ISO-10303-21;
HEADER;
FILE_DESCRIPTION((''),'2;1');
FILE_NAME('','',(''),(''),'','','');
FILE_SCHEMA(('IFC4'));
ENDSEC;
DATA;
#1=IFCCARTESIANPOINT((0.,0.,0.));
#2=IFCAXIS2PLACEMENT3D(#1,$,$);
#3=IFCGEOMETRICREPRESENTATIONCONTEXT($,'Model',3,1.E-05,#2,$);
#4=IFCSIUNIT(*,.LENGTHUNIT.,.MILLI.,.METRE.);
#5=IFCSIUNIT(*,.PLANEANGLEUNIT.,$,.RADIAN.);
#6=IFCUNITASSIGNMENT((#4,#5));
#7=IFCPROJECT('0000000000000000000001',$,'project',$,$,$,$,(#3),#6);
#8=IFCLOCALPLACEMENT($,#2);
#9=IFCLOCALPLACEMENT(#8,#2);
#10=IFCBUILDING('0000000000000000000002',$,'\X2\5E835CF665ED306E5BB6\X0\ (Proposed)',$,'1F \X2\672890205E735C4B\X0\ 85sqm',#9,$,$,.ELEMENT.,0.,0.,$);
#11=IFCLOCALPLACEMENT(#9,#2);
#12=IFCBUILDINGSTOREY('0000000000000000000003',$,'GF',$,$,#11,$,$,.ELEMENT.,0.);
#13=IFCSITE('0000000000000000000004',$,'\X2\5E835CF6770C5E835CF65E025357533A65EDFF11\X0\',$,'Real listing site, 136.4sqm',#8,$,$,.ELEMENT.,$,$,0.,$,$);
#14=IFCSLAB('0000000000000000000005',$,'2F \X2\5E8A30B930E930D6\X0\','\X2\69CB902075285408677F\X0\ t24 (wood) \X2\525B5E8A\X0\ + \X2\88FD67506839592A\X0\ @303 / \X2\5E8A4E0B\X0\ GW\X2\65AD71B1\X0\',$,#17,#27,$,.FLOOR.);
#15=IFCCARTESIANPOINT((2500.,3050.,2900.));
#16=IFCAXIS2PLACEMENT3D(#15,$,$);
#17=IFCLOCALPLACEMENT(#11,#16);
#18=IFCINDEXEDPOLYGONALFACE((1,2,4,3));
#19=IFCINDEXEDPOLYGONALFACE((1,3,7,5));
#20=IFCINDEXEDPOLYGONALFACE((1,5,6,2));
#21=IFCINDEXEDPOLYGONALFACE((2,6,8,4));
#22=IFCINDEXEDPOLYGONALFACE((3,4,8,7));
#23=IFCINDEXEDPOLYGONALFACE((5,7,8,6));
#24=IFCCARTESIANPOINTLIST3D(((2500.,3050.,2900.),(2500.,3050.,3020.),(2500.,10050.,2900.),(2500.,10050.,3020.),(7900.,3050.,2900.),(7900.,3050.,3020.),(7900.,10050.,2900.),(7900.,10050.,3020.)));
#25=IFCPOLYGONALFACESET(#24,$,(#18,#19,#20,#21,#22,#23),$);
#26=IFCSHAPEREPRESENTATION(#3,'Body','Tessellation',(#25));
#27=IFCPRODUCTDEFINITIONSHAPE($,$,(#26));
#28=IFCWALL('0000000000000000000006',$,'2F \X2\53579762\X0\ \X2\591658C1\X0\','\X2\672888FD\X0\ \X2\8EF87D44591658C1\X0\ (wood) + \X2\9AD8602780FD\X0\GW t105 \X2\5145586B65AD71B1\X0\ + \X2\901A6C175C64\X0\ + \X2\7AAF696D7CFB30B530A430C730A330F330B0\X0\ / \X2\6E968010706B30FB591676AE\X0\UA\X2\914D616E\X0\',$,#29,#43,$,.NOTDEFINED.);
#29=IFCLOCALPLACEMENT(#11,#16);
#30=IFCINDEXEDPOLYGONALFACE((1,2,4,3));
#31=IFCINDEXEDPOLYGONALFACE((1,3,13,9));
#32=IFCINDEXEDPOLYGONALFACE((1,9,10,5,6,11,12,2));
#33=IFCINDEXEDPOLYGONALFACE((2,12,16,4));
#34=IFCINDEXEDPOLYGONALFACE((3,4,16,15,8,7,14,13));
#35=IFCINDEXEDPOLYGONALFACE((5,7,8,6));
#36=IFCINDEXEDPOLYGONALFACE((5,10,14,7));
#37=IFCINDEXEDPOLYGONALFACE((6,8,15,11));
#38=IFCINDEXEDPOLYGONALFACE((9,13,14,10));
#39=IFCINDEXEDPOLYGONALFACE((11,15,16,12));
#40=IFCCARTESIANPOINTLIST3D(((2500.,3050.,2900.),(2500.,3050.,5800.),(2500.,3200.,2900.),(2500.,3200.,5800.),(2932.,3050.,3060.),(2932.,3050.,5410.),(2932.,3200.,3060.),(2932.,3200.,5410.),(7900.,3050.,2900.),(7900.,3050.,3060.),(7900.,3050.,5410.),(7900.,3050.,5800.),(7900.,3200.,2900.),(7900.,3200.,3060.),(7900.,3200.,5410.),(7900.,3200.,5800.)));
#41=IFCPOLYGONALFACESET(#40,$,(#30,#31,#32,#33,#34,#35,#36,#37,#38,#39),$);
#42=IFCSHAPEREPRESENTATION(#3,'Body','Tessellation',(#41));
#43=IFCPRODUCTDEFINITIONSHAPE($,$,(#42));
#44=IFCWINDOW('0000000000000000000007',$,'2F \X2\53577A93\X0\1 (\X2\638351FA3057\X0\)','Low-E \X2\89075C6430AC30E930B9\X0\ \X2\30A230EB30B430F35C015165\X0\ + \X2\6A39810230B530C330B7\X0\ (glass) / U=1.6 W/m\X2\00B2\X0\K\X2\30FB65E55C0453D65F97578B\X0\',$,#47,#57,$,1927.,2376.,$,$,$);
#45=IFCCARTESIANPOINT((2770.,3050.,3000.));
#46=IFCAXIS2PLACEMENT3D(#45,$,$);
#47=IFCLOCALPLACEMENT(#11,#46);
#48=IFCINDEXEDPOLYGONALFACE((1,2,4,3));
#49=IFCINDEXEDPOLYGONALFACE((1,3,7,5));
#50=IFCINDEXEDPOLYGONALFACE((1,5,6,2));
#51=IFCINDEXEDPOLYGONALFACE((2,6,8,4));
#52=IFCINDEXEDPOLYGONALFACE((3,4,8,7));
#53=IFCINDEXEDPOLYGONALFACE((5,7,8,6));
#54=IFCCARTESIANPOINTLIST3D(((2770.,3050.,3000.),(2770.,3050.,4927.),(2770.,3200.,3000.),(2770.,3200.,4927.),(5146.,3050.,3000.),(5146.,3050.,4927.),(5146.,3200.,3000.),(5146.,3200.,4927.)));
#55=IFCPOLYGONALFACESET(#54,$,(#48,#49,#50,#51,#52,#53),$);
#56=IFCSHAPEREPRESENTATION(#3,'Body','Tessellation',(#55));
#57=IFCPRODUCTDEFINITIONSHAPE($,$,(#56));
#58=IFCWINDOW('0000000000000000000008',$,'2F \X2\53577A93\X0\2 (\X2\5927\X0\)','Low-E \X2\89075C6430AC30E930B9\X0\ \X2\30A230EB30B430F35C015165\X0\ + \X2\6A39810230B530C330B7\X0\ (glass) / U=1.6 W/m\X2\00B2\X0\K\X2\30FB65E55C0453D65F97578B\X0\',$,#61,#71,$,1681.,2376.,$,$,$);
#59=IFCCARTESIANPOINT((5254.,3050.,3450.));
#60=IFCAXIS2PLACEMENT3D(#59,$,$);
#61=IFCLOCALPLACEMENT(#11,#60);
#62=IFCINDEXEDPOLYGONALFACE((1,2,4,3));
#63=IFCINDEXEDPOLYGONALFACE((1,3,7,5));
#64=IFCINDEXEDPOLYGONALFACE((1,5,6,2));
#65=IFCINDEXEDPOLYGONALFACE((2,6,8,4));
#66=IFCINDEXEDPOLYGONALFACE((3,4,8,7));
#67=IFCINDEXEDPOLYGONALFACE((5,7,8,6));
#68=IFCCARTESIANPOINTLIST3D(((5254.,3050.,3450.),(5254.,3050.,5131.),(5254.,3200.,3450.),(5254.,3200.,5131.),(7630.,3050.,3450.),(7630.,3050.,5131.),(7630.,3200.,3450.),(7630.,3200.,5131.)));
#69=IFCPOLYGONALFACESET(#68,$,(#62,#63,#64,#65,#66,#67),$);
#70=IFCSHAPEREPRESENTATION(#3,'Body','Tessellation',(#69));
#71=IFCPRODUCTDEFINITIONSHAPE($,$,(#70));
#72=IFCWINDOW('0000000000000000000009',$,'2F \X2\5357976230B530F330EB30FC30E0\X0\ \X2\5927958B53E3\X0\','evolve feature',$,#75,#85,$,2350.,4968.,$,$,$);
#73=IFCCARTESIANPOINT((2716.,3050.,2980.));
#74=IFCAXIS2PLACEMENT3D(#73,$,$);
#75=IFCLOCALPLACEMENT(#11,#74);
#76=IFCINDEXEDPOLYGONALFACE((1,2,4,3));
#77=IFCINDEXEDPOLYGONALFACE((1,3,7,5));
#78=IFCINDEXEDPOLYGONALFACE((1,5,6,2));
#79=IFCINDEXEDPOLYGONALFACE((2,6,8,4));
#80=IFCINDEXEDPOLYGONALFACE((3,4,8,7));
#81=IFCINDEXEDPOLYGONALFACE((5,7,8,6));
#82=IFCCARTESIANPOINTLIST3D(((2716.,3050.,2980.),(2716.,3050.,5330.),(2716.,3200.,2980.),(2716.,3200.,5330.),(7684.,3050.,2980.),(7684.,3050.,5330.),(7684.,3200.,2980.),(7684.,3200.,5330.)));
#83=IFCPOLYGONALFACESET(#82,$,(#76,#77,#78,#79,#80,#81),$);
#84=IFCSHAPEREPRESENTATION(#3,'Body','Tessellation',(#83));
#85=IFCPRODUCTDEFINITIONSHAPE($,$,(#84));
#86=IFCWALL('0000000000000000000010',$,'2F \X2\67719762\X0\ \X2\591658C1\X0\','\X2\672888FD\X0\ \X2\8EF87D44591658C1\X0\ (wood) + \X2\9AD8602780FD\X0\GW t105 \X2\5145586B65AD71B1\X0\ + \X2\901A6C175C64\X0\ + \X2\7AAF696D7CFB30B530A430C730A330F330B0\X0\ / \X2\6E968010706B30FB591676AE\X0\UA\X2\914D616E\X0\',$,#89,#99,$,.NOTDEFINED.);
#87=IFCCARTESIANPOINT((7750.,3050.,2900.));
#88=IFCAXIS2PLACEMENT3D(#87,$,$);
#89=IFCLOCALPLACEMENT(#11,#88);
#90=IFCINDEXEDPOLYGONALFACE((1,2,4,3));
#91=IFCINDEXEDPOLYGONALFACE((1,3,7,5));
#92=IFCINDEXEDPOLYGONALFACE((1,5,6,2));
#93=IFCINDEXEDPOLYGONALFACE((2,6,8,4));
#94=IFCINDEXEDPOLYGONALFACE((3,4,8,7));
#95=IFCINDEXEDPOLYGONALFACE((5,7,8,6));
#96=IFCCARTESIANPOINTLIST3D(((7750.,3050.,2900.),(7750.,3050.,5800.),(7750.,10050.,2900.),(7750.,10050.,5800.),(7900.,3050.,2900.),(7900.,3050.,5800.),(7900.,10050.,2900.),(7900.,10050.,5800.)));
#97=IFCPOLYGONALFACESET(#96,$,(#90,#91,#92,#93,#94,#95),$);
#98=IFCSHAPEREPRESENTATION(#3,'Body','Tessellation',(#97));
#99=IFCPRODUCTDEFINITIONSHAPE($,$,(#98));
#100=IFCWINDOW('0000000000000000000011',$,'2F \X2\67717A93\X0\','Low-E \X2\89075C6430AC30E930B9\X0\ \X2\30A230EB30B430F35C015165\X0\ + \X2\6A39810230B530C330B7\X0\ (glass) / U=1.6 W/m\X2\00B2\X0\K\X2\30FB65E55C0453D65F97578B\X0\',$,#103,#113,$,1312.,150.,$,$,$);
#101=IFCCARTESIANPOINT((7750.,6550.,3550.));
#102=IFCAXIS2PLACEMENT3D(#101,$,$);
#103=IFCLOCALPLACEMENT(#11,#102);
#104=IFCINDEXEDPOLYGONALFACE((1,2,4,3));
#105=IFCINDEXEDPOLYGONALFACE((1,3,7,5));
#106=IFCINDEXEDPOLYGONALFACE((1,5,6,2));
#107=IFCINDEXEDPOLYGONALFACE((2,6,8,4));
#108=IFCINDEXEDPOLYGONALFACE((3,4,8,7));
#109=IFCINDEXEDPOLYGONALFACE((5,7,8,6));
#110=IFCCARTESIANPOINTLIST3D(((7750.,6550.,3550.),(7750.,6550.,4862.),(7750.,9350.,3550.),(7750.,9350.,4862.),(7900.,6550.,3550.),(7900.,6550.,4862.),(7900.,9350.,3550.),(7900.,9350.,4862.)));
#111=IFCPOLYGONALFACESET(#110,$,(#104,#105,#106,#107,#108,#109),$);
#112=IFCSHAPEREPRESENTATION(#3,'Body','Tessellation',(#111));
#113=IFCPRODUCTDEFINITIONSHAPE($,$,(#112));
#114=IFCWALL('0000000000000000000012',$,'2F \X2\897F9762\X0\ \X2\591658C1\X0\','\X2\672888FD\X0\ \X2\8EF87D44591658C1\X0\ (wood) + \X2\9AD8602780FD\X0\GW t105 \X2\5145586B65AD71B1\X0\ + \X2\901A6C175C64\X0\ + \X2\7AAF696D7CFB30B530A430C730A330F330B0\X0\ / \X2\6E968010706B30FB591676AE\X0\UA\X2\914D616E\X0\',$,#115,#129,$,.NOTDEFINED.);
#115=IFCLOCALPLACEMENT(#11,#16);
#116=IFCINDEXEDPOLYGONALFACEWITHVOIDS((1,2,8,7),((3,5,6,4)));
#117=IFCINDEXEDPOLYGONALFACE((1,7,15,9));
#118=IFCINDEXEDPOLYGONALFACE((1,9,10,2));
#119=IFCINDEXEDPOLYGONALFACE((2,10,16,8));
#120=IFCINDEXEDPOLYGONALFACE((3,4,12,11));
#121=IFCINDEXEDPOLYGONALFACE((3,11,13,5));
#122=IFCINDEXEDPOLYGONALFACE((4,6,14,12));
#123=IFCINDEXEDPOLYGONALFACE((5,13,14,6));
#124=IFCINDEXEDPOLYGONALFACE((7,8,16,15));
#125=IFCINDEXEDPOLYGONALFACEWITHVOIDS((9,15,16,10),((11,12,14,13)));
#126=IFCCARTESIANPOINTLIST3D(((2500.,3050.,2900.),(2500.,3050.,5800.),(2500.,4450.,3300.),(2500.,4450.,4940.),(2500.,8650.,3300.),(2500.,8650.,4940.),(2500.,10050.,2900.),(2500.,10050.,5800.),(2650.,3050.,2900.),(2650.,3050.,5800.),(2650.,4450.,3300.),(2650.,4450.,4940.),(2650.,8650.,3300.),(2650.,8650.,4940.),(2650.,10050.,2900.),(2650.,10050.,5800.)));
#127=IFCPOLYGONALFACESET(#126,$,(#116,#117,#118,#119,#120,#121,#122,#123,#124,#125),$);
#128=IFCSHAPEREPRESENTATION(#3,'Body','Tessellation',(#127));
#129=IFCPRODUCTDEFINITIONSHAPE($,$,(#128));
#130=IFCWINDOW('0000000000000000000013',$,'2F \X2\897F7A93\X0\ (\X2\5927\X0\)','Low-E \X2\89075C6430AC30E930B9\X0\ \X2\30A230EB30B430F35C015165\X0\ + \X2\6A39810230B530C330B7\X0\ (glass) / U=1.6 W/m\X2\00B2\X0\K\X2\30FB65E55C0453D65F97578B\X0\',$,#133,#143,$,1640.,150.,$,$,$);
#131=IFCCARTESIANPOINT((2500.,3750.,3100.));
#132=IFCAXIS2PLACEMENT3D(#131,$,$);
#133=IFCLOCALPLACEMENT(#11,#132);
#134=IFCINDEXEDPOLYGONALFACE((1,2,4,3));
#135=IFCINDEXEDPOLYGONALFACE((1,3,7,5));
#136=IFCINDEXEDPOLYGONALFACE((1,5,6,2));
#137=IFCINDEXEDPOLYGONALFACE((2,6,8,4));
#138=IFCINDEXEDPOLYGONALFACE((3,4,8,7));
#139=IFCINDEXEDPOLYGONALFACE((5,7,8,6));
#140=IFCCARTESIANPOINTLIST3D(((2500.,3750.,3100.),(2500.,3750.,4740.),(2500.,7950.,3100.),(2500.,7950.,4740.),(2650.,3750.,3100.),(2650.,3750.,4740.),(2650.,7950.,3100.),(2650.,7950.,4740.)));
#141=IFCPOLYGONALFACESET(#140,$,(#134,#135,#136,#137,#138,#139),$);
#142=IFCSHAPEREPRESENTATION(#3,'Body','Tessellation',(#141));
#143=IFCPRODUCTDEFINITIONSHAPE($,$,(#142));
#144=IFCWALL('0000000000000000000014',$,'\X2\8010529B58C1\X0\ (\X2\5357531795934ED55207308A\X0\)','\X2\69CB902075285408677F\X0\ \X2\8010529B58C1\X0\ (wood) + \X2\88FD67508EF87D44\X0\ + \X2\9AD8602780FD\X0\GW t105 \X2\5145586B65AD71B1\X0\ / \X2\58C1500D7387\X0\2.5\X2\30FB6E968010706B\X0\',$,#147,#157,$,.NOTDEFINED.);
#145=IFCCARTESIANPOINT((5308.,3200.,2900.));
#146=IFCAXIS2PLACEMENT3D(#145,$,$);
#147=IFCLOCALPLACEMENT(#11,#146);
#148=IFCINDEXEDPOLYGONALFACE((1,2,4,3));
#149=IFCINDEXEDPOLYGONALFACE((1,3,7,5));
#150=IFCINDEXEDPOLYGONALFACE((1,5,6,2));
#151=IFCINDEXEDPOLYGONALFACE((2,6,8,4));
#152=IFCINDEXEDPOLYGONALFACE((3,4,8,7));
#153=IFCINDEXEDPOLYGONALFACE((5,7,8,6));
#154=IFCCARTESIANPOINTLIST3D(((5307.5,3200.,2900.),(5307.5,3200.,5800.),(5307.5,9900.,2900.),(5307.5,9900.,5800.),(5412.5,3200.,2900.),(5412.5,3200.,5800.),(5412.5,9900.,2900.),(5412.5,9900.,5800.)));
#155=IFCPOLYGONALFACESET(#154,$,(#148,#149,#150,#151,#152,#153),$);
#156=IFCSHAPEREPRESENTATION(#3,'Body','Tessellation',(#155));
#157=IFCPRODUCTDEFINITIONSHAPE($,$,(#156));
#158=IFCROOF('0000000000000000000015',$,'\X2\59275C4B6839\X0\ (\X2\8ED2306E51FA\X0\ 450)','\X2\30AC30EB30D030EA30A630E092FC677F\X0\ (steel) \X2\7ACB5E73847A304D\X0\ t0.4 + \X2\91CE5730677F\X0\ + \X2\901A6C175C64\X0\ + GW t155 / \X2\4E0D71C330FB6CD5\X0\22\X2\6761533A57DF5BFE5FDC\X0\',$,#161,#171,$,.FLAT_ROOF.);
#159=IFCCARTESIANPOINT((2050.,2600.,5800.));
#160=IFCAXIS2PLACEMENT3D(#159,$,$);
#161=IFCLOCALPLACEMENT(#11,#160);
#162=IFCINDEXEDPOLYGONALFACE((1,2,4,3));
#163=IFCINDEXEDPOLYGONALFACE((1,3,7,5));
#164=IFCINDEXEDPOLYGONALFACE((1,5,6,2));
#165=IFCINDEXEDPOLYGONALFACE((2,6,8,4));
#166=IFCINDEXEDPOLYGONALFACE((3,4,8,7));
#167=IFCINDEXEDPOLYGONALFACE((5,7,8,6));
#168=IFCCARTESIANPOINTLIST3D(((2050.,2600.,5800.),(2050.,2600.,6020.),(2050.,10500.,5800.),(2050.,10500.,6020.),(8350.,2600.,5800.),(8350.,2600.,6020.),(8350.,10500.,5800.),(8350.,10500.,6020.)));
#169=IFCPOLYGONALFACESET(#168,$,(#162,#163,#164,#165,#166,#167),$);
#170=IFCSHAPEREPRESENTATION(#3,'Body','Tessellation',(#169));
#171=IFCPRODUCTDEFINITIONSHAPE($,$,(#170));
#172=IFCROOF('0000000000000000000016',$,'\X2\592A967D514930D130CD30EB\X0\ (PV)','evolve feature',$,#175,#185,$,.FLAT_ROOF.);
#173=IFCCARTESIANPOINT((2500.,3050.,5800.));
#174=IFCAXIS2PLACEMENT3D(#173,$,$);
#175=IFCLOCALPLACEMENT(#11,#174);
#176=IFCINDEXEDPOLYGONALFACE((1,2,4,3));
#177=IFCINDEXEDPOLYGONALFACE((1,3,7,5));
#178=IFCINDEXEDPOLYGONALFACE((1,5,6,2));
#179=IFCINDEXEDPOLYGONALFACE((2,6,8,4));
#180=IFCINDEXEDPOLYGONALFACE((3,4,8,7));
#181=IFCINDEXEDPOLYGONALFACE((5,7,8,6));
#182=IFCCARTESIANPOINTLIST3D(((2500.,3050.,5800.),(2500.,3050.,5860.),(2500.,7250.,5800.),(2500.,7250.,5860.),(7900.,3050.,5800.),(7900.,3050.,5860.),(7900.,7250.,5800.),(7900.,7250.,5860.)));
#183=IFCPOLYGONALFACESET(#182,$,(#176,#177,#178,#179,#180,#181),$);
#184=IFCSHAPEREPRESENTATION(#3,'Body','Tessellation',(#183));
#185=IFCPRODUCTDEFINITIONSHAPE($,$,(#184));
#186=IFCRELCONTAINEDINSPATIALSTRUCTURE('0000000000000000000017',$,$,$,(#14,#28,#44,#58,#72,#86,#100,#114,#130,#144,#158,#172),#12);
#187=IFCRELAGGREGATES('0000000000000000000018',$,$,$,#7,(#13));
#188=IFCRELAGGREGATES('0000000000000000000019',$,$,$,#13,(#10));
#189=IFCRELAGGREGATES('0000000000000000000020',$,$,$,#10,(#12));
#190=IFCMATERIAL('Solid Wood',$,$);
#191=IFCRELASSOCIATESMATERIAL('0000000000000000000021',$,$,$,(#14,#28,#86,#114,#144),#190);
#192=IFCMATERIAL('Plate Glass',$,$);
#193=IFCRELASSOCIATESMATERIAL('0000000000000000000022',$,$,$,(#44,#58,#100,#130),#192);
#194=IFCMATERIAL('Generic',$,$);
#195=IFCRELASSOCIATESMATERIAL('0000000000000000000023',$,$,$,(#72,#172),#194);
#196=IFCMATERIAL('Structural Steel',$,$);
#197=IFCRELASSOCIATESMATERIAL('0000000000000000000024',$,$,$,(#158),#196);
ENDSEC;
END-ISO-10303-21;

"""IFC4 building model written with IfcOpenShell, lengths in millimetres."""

from ifc_helpers import new_model, si_unit, frame, frame_2d, origin, place, context, project, spatial, rectangle, extrude, material, element, fill, save


model = new_model("IFC4")

# Units and contexts
model_context = context("Model", 3, precision=1e-05, world=origin())
ifc_project = project(units=[si_unit("LENGTHUNIT", "METRE", prefix="MILLI"), si_unit("PLANEANGLEUNIT", "RADIAN")], contexts=[model_context])

# Site, building, storey
site_placement = place(None, origin())
site = spatial("IfcSite", under=ifc_project, at=site_placement, Name="広島県広島市南区旭１", ObjectType="Real listing site, 136.4sqm", CompositionType="ELEMENT", RefElevation=0.0)
building_placement = place(site_placement, origin())
building = spatial("IfcBuilding", under=site, at=building_placement, Name="広島旭の家 (Proposed)", ObjectType="1F 木造平屋 85sqm", CompositionType="ELEMENT", ElevationOfRefHeight=0.0, ElevationOfTerrain=0.0)
storey_placement = place(building_placement, origin())
storey = spatial("IfcBuildingStorey", under=building, at=storey_placement, Name="GF", CompositionType="ELEMENT", Elevation=0.0)

# Slab
ifc_material_1 = material(Name="Solid Wood")
slab_placement = place(storey_placement, frame((2500.0, 3050.0, 2900.0)))
element("IfcSlab", 1, at=slab_placement, inside=storey, material=ifc_material_1, Name="2F 床スラブ", Description="構造用合板 t24 (wood) 剛床 + 製材根太 @303 / 床下 GW断熱", PredefinedType="FLOOR", context=model_context, shape_type="SweptSolid", body=[
    extrude(rectangle(XDim=5400.0, YDim=7000.0, at=frame_2d((2700.0, 3500.0))), frame((2500.0, 3050.0, 2900.0)), (0.0, 0.0, 1.0), 120.0),
])

# Wall, openings, windows
wall_1_placement = place(storey_placement, frame((2500.0, 3050.0, 2900.0)))
wall_1 = element("IfcWall", 2, at=wall_1_placement, inside=storey, material=ifc_material_1, Name="2F 南面 外壁", Description="木製 軸組外壁 (wood) + 高性能GW t105 充填断熱 + 通気層 + 窯業系サイディング / 準耐火・外皮UA配慮", PredefinedType="NOTDEFINED", context=model_context, shape_type="SweptSolid", body=[
    extrude(rectangle(XDim=5400.0, YDim=150.0, at=frame_2d((2700.0, 75.0))), frame((2500.0, 3050.0, 2900.0)), (0.0, 0.0, 1.0), 2900.0),
])
opening_1_placement = place(storey_placement, frame((2770.0, 3050.0, 3000.0)))
opening_1 = element("IfcOpeningElement", 3, at=opening_1_placement, cuts=wall_1, PredefinedType="NOTDEFINED", context=model_context, shape_type="SweptSolid", body=[
    extrude(rectangle(XDim=2376.0, YDim=150.0, at=frame_2d((1188.0, 75.0))), frame((2770.0, 3050.0, 3000.0)), (0.0, 0.0, 1.0), 1927.0),
])
opening_2_placement = place(storey_placement, frame((5254.0, 3050.0, 3450.0)))
opening_2 = element("IfcOpeningElement", 4, at=opening_2_placement, cuts=wall_1, PredefinedType="NOTDEFINED", context=model_context, shape_type="SweptSolid", body=[
    extrude(rectangle(XDim=2376.0, YDim=150.0, at=frame_2d((1188.0, 75.0))), frame((5254.0, 3050.0, 3450.0)), (0.0, 0.0, 1.0), 1681.0),
])
opening_3_placement = place(storey_placement, frame((2716.0, 3050.0, 2980.0)))
opening_3 = element("IfcOpeningElement", 5, at=opening_3_placement, cuts=wall_1, PredefinedType="NOTDEFINED", context=model_context, shape_type="SweptSolid", body=[
    extrude(rectangle(XDim=4968.0, YDim=150.0, at=frame_2d((2484.0, 75.0))), frame((2716.0, 3050.0, 2980.0)), (0.0, 0.0, 1.0), 2350.0),
])
ifc_material_2 = material(Name="Plate Glass")
window_1_placement = place(storey_placement, frame((2770.0, 3050.0, 3000.0)))
window_1 = element("IfcWindow", 6, at=window_1_placement, inside=storey, material=ifc_material_2, Name="2F 南窓1 (掃出し)", Description="Low-E 複層ガラス アルゴン封入 + 樹脂サッシ (glass) / U=1.6 W/m²K・日射取得型", OverallHeight=1927.0, OverallWidth=2376.0, context=model_context, shape_type="SweptSolid", body=[
    extrude(rectangle(XDim=2376.0, YDim=150.0, at=frame_2d((1188.0, 75.0))), frame((2770.0, 3050.0, 3000.0)), (0.0, 0.0, 1.0), 1927.0),
])
fill(opening_1, window_1)
window_2_placement = place(storey_placement, frame((5254.0, 3050.0, 3450.0)))
window_2 = element("IfcWindow", 7, at=window_2_placement, inside=storey, material=ifc_material_2, Name="2F 南窓2 (大)", Description="Low-E 複層ガラス アルゴン封入 + 樹脂サッシ (glass) / U=1.6 W/m²K・日射取得型", OverallHeight=1681.0, OverallWidth=2376.0, context=model_context, shape_type="SweptSolid", body=[
    extrude(rectangle(XDim=2376.0, YDim=150.0, at=frame_2d((1188.0, 75.0))), frame((5254.0, 3050.0, 3450.0)), (0.0, 0.0, 1.0), 1681.0),
])
fill(opening_2, window_2)
ifc_material_3 = material(Name="Generic")
window_3_placement = place(storey_placement, frame((2716.0, 3050.0, 2980.0)))
window_3 = element("IfcWindow", 8, at=window_3_placement, inside=storey, material=ifc_material_3, Name="2F 南面サンルーム 大開口", Description="evolve feature", OverallHeight=2350.0, OverallWidth=4968.0, context=model_context, shape_type="SweptSolid", body=[
    extrude(rectangle(XDim=4968.0, YDim=150.0, at=frame_2d((2484.0, 75.0))), frame((2716.0, 3050.0, 2980.0)), (0.0, 0.0, 1.0), 2350.0),
])
fill(opening_3, window_3)

# Walls, openings, windows
wall_2_placement = place(storey_placement, frame((7750.0, 3050.0, 2900.0)))
wall_2 = element("IfcWall", 9, at=wall_2_placement, inside=storey, material=ifc_material_1, Name="2F 東面 外壁", Description="木製 軸組外壁 (wood) + 高性能GW t105 充填断熱 + 通気層 + 窯業系サイディング / 準耐火・外皮UA配慮", PredefinedType="NOTDEFINED", context=model_context, shape_type="SweptSolid", body=[
    extrude(rectangle(XDim=150.0, YDim=7000.0, at=frame_2d((75.0, 3500.0))), frame((7750.0, 3050.0, 2900.0)), (0.0, 0.0, 1.0), 2900.0),
])
opening_4_placement = place(storey_placement, frame((7750.0, 6550.0, 3550.0)))
opening_4 = element("IfcOpeningElement", 10, at=opening_4_placement, cuts=wall_2, PredefinedType="NOTDEFINED", context=model_context, shape_type="SweptSolid", body=[
    extrude(rectangle(XDim=150.0, YDim=2800.0, at=frame_2d((75.0, 1400.0))), frame((7750.0, 6550.0, 3550.0)), (0.0, 0.0, 1.0), 1312.0),
])
window_4_placement = place(storey_placement, frame((7750.0, 6550.0, 3550.0)))
window_4 = element("IfcWindow", 11, at=window_4_placement, inside=storey, material=ifc_material_2, Name="2F 東窓", Description="Low-E 複層ガラス アルゴン封入 + 樹脂サッシ (glass) / U=1.6 W/m²K・日射取得型", OverallHeight=1312.0, OverallWidth=150.0, context=model_context, shape_type="SweptSolid", body=[
    extrude(rectangle(XDim=150.0, YDim=2800.0, at=frame_2d((75.0, 1400.0))), frame((7750.0, 6550.0, 3550.0)), (0.0, 0.0, 1.0), 1312.0),
])
fill(opening_4, window_4)
wall_3_placement = place(storey_placement, frame((2500.0, 3050.0, 2900.0)))
wall_3 = element("IfcWall", 12, at=wall_3_placement, inside=storey, material=ifc_material_1, Name="2F 西面 外壁", Description="木製 軸組外壁 (wood) + 高性能GW t105 充填断熱 + 通気層 + 窯業系サイディング / 準耐火・外皮UA配慮", PredefinedType="NOTDEFINED", context=model_context, shape_type="SweptSolid", body=[
    extrude(rectangle(XDim=150.0, YDim=7000.0, at=frame_2d((75.0, 3500.0))), frame((2500.0, 3050.0, 2900.0)), (0.0, 0.0, 1.0), 2900.0),
])
opening_5_placement = place(storey_placement, frame((2500.0, 3750.0, 3100.0)))
opening_5 = element("IfcOpeningElement", 13, at=opening_5_placement, cuts=wall_3, PredefinedType="NOTDEFINED", context=model_context, shape_type="SweptSolid", body=[
    extrude(rectangle(XDim=150.0, YDim=4200.0, at=frame_2d((75.0, 2100.0))), frame((2500.0, 3750.0, 3100.0)), (0.0, 0.0, 1.0), 1640.0),
])
window_5_placement = place(storey_placement, frame((2500.0, 3750.0, 3100.0)))
window_5 = element("IfcWindow", 14, at=window_5_placement, inside=storey, material=ifc_material_2, Name="2F 西窓 (大)", Description="Low-E 複層ガラス アルゴン封入 + 樹脂サッシ (glass) / U=1.6 W/m²K・日射取得型", OverallHeight=1640.0, OverallWidth=150.0, context=model_context, shape_type="SweptSolid", body=[
    extrude(rectangle(XDim=150.0, YDim=4200.0, at=frame_2d((75.0, 2100.0))), frame((2500.0, 3750.0, 3100.0)), (0.0, 0.0, 1.0), 1640.0),
])
fill(opening_5, window_5)

# Wall
wall_4_placement = place(storey_placement, frame((5308.0, 3200.0, 2900.0)))
element("IfcWall", 15, at=wall_4_placement, inside=storey, material=ifc_material_1, Name="耐力壁 (南北間仕切り)", Description="構造用合板 耐力壁 (wood) + 製材軸組 + 高性能GW t105 充填断熱 / 壁倍率2.5・準耐火", PredefinedType="NOTDEFINED", context=model_context, shape_type="SweptSolid", body=[
    extrude(rectangle(XDim=105.0, YDim=6700.0, at=frame_2d((52.0, 3350.0))), frame((5308.0, 3200.0, 2900.0)), (0.0, 0.0, 1.0), 2900.0),
])

# Roofs
ifc_material_4 = material(Name="Structural Steel")
roof_1_placement = place(storey_placement, frame((2050.0, 2600.0, 5800.0)))
element("IfcRoof", 16, at=roof_1_placement, inside=storey, material=ifc_material_4, Name="大屋根 (軒の出 450)", Description="ガルバリウム鋼板 (steel) 立平葺き t0.4 + 野地板 + 通気層 + GW t155 / 不燃・法22条区域対応", PredefinedType="FLAT_ROOF", context=model_context, shape_type="SweptSolid", body=[
    extrude(rectangle(XDim=6300.0, YDim=7900.0, at=frame_2d((3150.0, 3950.0))), frame((2050.0, 2600.0, 5800.0)), (0.0, 0.0, 1.0), 220.0),
])
roof_2_placement = place(storey_placement, frame((2500.0, 3050.0, 5800.0)))
element("IfcRoof", 17, at=roof_2_placement, inside=storey, material=ifc_material_3, Name="太陽光パネル (PV)", Description="evolve feature", PredefinedType="FLAT_ROOF", context=model_context, shape_type="SweptSolid", body=[
    extrude(rectangle(XDim=5400.0, YDim=4200.0, at=frame_2d((2700.0, 2100.0))), frame((2500.0, 3050.0, 5800.0)), (0.0, 0.0, 1.0), 60.0),
])

save(model, "model.ifc")
